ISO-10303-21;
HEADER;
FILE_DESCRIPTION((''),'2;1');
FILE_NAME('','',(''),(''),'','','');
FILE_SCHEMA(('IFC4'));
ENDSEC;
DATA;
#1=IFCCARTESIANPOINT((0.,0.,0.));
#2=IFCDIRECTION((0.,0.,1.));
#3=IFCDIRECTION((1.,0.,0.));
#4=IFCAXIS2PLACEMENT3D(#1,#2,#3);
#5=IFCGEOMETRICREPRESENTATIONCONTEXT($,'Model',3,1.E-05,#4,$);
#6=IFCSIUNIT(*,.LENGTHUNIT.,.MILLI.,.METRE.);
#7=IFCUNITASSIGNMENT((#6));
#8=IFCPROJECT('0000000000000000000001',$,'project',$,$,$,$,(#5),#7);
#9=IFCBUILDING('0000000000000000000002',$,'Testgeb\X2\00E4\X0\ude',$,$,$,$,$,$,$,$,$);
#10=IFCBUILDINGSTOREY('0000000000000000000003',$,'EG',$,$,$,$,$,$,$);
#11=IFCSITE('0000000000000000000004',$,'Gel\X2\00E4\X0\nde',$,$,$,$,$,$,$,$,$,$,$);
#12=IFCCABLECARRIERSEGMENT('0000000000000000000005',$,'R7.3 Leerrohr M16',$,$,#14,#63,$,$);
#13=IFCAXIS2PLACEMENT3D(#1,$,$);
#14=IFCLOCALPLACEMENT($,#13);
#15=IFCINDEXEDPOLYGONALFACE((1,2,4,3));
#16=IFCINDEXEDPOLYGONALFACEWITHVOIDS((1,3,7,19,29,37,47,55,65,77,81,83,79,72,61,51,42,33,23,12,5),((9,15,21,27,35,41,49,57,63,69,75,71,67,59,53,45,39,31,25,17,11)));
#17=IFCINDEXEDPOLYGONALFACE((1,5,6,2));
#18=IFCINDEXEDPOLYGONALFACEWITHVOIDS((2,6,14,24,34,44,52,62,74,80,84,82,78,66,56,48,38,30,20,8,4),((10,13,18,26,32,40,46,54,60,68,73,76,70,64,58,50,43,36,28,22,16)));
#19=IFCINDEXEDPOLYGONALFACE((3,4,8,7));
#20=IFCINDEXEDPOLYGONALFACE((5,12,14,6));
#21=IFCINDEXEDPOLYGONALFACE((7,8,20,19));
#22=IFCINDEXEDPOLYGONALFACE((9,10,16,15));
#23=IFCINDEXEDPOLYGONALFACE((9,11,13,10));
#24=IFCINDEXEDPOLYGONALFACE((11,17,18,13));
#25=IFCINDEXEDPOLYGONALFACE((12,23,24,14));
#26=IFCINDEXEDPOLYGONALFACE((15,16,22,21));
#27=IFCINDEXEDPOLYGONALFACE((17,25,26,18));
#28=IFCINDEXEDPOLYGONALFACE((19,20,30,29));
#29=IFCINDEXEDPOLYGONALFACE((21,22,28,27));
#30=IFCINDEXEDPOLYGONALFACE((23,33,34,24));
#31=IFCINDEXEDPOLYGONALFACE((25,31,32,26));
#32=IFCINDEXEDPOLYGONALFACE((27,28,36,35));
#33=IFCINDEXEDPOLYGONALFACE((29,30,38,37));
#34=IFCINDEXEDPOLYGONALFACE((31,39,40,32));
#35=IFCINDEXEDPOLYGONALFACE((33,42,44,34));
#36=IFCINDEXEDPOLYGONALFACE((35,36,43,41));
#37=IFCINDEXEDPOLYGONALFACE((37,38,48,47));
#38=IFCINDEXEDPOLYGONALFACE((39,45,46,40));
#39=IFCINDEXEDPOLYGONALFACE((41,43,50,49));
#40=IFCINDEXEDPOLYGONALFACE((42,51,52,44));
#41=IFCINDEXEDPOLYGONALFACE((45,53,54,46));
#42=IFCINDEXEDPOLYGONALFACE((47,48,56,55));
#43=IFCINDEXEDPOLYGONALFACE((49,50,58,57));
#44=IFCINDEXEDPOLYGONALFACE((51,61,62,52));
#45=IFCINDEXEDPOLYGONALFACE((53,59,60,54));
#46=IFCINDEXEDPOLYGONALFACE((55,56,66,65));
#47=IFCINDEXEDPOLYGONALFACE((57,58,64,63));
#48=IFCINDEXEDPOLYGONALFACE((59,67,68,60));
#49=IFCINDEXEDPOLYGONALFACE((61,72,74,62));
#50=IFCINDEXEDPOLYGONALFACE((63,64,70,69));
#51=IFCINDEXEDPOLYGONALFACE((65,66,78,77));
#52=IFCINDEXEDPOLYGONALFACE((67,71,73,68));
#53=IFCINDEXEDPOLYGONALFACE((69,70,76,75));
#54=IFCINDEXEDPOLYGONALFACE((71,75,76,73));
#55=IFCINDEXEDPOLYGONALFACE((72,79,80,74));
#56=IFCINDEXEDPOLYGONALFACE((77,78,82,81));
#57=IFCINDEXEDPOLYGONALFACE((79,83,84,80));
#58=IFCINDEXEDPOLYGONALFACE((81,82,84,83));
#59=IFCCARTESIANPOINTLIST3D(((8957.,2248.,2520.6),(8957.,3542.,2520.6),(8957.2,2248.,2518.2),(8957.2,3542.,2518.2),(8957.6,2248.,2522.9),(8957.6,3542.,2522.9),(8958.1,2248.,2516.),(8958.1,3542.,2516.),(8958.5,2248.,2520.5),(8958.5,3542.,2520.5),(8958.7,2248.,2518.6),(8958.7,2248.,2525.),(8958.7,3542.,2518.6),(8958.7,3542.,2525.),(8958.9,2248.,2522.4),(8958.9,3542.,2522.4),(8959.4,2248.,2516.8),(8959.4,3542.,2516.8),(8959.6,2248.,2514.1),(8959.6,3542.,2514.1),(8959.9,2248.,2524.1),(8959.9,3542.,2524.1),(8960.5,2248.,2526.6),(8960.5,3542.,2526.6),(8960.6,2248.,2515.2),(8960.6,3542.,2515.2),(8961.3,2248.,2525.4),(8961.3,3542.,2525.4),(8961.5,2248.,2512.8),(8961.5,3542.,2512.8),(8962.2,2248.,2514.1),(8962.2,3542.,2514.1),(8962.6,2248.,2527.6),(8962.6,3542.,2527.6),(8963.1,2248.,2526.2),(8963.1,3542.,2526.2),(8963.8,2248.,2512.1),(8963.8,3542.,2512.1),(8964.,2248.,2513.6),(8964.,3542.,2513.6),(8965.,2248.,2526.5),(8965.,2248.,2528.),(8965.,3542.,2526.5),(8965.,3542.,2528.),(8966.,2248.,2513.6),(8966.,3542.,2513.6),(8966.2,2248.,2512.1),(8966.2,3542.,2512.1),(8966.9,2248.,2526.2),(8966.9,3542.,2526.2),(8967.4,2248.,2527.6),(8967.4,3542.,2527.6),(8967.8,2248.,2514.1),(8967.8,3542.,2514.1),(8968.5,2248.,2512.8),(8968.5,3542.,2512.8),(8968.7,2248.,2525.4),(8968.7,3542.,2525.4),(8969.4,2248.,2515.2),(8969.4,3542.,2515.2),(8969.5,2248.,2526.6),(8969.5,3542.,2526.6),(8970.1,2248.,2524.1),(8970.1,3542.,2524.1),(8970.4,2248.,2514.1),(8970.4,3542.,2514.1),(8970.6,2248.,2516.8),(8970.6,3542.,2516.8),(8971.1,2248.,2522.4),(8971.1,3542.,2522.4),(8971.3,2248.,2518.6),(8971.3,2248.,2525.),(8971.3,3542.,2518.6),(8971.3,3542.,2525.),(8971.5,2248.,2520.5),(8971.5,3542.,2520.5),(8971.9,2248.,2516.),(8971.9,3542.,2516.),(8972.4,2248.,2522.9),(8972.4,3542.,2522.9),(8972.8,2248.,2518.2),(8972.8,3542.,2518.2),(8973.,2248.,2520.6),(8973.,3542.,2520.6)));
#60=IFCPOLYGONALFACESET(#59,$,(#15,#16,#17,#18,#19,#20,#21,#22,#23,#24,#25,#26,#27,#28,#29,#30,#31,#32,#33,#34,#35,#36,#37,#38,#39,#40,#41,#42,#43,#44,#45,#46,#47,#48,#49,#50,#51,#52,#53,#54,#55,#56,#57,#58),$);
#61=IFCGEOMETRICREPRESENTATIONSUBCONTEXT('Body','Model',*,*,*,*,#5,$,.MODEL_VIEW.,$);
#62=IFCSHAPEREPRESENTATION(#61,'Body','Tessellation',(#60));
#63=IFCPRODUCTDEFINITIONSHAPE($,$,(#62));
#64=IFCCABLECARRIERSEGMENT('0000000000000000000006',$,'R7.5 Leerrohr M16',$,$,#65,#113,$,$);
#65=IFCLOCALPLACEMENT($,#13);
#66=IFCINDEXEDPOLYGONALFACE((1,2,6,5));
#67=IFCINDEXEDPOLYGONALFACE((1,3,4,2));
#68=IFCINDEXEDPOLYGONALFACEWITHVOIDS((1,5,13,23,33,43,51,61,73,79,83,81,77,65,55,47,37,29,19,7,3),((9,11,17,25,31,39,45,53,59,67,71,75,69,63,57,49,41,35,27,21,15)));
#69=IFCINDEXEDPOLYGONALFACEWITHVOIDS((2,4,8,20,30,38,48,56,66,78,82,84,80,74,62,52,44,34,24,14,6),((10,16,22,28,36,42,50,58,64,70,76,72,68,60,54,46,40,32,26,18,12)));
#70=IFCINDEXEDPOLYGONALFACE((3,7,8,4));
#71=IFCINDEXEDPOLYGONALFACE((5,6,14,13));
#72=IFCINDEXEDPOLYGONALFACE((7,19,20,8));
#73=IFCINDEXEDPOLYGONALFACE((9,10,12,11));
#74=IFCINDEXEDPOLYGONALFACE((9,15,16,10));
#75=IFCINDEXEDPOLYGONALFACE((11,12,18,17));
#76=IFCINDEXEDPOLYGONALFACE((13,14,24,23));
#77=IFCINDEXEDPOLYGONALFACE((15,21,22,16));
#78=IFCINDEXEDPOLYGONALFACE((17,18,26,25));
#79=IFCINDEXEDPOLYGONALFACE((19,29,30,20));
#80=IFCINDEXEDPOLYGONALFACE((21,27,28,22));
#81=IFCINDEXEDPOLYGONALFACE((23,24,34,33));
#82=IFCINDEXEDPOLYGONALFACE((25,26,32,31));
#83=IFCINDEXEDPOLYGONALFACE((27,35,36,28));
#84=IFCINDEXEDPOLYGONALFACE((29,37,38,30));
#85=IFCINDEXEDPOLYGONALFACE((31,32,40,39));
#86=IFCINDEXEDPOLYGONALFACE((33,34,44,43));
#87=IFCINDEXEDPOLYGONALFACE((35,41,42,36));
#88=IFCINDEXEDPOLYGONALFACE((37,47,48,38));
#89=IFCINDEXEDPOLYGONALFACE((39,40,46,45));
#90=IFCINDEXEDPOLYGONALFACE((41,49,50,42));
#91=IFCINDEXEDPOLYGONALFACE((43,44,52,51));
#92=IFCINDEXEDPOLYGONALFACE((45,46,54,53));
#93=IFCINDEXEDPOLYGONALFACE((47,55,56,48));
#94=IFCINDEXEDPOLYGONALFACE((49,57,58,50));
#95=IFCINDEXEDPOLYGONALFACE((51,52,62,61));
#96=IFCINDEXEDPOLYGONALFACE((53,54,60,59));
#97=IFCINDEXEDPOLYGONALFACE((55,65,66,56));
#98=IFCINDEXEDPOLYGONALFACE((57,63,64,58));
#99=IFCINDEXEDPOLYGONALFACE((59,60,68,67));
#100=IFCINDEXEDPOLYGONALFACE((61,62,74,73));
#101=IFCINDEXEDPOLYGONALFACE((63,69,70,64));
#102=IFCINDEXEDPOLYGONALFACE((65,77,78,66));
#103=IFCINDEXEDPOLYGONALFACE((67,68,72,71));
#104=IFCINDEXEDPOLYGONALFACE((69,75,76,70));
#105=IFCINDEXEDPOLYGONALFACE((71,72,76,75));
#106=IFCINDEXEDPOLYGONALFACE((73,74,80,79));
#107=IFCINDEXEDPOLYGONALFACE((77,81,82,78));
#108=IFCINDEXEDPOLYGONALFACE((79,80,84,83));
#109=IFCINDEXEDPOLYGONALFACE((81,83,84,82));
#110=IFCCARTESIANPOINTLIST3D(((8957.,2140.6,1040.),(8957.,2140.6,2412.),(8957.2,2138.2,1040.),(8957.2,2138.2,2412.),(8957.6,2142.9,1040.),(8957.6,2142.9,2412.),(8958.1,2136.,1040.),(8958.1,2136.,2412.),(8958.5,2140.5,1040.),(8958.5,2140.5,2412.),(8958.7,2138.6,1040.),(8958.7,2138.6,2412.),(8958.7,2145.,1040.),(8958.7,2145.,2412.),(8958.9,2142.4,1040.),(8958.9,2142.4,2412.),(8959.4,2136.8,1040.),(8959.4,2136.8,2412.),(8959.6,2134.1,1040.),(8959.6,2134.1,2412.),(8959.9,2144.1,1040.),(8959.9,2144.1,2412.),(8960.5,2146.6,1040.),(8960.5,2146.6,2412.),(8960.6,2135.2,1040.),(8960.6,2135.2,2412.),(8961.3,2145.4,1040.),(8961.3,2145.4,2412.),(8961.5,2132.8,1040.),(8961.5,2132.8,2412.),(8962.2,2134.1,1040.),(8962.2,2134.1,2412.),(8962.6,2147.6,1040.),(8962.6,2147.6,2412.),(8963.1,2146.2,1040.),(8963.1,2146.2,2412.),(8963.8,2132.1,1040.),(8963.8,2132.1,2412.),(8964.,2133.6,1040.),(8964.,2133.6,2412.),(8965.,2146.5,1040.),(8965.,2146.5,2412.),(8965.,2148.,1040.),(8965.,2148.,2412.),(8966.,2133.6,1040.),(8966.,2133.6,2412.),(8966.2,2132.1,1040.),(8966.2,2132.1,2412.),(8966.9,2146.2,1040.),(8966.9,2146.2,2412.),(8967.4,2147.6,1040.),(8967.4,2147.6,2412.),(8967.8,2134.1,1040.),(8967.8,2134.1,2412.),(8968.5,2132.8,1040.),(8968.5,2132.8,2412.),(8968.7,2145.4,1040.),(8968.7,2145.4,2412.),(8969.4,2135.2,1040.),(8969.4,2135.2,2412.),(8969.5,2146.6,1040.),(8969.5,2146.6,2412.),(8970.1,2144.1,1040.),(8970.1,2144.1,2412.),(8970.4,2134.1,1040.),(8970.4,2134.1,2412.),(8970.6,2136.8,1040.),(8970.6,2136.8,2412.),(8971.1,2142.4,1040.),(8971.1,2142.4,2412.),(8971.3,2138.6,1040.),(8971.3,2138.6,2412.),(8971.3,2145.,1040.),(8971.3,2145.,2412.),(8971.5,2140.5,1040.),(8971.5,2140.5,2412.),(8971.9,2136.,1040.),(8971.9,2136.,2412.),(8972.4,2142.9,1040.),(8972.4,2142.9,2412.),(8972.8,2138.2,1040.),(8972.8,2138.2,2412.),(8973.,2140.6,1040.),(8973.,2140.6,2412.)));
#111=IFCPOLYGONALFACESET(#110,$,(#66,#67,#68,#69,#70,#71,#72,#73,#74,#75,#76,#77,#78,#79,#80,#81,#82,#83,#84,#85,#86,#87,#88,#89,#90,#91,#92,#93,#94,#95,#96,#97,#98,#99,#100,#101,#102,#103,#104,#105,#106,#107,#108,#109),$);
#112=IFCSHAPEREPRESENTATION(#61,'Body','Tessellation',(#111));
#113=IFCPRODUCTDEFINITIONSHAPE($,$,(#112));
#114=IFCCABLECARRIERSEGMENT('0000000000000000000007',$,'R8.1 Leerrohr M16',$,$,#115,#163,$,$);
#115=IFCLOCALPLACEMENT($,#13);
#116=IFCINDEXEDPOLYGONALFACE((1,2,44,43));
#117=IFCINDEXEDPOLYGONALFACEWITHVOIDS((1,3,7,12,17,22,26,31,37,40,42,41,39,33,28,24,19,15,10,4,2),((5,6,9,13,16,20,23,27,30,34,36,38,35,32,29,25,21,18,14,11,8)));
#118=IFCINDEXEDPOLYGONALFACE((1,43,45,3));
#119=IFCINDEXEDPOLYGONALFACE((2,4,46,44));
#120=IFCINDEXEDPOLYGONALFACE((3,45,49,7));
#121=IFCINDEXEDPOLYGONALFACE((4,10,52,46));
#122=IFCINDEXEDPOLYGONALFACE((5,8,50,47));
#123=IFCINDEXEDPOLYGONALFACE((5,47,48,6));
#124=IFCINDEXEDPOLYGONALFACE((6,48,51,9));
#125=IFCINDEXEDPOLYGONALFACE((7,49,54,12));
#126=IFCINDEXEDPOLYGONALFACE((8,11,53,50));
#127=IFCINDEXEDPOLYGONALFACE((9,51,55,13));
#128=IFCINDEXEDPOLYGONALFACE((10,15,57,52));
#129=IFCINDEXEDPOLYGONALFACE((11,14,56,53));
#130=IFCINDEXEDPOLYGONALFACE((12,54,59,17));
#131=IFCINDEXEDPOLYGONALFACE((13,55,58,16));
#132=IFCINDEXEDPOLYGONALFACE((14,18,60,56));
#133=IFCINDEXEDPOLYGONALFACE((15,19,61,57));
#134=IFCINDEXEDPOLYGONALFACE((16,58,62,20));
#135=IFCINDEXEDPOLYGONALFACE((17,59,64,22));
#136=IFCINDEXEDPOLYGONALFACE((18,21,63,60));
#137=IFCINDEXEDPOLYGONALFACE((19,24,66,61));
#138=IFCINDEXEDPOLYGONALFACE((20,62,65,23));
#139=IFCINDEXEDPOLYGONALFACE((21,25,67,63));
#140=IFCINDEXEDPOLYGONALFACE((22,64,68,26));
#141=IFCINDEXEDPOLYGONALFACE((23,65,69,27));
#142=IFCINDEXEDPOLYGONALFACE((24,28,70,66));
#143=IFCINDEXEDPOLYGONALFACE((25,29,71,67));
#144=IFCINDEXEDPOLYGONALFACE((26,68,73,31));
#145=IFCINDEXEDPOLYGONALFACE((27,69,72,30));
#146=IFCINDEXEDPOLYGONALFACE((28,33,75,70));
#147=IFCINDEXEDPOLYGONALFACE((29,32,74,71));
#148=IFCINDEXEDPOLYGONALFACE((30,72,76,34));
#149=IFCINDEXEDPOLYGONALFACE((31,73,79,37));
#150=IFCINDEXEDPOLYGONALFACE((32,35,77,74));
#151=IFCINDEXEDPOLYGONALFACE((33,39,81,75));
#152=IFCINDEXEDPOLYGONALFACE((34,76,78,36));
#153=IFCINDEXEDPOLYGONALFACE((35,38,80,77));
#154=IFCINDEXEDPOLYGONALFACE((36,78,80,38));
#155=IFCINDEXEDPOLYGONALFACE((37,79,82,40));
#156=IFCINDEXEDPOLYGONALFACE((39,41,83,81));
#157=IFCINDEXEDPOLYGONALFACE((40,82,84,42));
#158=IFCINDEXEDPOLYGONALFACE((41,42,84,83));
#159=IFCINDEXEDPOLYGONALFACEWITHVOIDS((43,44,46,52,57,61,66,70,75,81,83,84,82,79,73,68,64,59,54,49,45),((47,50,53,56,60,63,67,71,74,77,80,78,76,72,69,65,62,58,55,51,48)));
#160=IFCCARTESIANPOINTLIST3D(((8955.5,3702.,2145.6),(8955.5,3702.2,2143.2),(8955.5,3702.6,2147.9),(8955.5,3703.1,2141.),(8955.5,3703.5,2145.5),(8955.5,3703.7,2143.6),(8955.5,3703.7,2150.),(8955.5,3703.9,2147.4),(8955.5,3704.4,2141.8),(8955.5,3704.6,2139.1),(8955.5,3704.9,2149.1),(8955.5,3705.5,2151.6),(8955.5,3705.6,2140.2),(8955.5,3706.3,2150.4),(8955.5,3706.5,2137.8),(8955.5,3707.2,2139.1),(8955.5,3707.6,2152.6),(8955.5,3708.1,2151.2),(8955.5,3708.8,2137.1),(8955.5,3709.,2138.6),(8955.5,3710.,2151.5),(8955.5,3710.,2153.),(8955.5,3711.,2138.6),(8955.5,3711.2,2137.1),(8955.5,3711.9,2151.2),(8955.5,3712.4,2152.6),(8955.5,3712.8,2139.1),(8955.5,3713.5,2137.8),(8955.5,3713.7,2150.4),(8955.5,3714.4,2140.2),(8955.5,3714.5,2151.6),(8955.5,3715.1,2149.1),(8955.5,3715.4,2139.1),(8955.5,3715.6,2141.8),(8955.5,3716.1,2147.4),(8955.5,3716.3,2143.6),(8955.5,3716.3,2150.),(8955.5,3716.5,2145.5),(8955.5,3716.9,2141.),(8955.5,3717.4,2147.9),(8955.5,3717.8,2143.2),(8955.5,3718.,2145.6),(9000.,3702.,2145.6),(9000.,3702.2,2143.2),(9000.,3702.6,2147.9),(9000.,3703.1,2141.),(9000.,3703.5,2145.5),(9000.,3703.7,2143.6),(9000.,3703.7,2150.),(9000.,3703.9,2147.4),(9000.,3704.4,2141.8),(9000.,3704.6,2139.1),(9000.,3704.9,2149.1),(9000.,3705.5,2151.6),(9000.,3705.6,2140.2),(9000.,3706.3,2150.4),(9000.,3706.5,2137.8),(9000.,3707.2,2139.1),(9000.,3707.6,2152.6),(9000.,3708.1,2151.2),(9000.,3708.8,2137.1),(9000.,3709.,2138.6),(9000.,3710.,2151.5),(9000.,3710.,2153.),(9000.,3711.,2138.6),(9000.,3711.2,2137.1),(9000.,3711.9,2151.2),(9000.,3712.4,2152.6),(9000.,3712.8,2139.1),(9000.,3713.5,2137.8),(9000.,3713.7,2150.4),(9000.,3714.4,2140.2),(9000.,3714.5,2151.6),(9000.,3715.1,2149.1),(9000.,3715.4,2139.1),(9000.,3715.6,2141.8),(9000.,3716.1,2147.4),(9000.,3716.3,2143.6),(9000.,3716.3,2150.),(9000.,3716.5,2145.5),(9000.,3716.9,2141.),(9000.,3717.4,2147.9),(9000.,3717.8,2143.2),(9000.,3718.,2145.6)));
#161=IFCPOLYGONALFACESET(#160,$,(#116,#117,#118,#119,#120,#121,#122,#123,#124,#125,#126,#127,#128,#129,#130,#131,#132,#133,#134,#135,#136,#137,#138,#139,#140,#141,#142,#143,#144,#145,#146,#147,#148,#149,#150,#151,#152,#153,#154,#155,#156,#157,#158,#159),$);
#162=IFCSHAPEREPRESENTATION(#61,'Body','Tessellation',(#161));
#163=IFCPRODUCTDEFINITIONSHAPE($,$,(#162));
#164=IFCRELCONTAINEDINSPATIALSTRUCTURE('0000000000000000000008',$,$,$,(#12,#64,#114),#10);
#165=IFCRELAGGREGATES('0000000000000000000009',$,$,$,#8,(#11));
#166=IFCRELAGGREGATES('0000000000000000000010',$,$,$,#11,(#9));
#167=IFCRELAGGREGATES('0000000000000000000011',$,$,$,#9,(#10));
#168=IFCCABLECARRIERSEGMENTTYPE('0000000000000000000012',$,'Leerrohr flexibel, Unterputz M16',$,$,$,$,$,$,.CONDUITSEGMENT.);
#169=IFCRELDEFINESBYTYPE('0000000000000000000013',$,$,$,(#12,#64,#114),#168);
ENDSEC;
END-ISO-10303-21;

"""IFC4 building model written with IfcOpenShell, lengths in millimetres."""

from ifc_helpers import new_model, si_unit, frame, origin_with_axes, place, context, subcontext, project, spatial, hollow_circle, extrude, type_object, element, save


model = new_model("IFC4")

# Units and contexts
model_context = context("Model", 3, precision=1e-05, world=origin_with_axes())
body_context = subcontext(model_context, "Body", "Model", "MODEL_VIEW")
ifc_project = project(units=[si_unit("LENGTHUNIT", "METRE", prefix="MILLI")], contexts=[model_context])

# Site, building, storey
site = spatial("IfcSite", under=ifc_project, Name="Gelände")
building = spatial("IfcBuilding", under=site, Name="Testgebäude")
storey = spatial("IfcBuildingStorey", under=building, Name="EG")

# Cable carrier segments
cable_carrier_segment_type_1 = type_object("IfcCableCarrierSegmentType", Name="Leerrohr flexibel, Unterputz M16", PredefinedType="CONDUITSEGMENT")
cable_carrier_segment_1_placement = place(None, frame((8965.0, 3542.0, 2520.0), z_axis=(0.0, -1.0, 0.0), x_axis=(0.0, 0.0, 1.0)))
element("IfcCableCarrierSegment", 1, at=cable_carrier_segment_1_placement, inside=storey, type_object=cable_carrier_segment_type_1, Name="R7.3 Leerrohr M16", context=body_context, shape_type="SweptSolid", body=[
    extrude(hollow_circle(Radius=8.0, WallThickness=1.5), None, (0.0, 0.0, 1.0), 1294.0),
])
cable_carrier_segment_2_placement = place(None, frame((8965.0, 2140.0, 2412.0), z_axis=(0.0, 0.0, -1.0), x_axis=(0.0, 1.0, 0.0)))
element("IfcCableCarrierSegment", 2, at=cable_carrier_segment_2_placement, inside=storey, type_object=cable_carrier_segment_type_1, Name="R7.5 Leerrohr M16", context=body_context, shape_type="SweptSolid", body=[
    extrude(hollow_circle(Radius=8.0, WallThickness=1.5), None, (0.0, 0.0, 1.0), 1372.0),
])
cable_carrier_segment_3_placement = place(None, frame((9000.0, 3710.0, 2145.0), z_axis=(-1.0, 0.0, 0.0), x_axis=(0.0, 0.0, 1.0)))
element("IfcCableCarrierSegment", 3, at=cable_carrier_segment_3_placement, inside=storey, type_object=cable_carrier_segment_type_1, Name="R8.1 Leerrohr M16", context=body_context, shape_type="SweptSolid", body=[
    extrude(hollow_circle(Radius=8.0, WallThickness=1.5), None, (0.0, 0.0, 1.0), 44.5),
])

save(model, "model.ifc")
